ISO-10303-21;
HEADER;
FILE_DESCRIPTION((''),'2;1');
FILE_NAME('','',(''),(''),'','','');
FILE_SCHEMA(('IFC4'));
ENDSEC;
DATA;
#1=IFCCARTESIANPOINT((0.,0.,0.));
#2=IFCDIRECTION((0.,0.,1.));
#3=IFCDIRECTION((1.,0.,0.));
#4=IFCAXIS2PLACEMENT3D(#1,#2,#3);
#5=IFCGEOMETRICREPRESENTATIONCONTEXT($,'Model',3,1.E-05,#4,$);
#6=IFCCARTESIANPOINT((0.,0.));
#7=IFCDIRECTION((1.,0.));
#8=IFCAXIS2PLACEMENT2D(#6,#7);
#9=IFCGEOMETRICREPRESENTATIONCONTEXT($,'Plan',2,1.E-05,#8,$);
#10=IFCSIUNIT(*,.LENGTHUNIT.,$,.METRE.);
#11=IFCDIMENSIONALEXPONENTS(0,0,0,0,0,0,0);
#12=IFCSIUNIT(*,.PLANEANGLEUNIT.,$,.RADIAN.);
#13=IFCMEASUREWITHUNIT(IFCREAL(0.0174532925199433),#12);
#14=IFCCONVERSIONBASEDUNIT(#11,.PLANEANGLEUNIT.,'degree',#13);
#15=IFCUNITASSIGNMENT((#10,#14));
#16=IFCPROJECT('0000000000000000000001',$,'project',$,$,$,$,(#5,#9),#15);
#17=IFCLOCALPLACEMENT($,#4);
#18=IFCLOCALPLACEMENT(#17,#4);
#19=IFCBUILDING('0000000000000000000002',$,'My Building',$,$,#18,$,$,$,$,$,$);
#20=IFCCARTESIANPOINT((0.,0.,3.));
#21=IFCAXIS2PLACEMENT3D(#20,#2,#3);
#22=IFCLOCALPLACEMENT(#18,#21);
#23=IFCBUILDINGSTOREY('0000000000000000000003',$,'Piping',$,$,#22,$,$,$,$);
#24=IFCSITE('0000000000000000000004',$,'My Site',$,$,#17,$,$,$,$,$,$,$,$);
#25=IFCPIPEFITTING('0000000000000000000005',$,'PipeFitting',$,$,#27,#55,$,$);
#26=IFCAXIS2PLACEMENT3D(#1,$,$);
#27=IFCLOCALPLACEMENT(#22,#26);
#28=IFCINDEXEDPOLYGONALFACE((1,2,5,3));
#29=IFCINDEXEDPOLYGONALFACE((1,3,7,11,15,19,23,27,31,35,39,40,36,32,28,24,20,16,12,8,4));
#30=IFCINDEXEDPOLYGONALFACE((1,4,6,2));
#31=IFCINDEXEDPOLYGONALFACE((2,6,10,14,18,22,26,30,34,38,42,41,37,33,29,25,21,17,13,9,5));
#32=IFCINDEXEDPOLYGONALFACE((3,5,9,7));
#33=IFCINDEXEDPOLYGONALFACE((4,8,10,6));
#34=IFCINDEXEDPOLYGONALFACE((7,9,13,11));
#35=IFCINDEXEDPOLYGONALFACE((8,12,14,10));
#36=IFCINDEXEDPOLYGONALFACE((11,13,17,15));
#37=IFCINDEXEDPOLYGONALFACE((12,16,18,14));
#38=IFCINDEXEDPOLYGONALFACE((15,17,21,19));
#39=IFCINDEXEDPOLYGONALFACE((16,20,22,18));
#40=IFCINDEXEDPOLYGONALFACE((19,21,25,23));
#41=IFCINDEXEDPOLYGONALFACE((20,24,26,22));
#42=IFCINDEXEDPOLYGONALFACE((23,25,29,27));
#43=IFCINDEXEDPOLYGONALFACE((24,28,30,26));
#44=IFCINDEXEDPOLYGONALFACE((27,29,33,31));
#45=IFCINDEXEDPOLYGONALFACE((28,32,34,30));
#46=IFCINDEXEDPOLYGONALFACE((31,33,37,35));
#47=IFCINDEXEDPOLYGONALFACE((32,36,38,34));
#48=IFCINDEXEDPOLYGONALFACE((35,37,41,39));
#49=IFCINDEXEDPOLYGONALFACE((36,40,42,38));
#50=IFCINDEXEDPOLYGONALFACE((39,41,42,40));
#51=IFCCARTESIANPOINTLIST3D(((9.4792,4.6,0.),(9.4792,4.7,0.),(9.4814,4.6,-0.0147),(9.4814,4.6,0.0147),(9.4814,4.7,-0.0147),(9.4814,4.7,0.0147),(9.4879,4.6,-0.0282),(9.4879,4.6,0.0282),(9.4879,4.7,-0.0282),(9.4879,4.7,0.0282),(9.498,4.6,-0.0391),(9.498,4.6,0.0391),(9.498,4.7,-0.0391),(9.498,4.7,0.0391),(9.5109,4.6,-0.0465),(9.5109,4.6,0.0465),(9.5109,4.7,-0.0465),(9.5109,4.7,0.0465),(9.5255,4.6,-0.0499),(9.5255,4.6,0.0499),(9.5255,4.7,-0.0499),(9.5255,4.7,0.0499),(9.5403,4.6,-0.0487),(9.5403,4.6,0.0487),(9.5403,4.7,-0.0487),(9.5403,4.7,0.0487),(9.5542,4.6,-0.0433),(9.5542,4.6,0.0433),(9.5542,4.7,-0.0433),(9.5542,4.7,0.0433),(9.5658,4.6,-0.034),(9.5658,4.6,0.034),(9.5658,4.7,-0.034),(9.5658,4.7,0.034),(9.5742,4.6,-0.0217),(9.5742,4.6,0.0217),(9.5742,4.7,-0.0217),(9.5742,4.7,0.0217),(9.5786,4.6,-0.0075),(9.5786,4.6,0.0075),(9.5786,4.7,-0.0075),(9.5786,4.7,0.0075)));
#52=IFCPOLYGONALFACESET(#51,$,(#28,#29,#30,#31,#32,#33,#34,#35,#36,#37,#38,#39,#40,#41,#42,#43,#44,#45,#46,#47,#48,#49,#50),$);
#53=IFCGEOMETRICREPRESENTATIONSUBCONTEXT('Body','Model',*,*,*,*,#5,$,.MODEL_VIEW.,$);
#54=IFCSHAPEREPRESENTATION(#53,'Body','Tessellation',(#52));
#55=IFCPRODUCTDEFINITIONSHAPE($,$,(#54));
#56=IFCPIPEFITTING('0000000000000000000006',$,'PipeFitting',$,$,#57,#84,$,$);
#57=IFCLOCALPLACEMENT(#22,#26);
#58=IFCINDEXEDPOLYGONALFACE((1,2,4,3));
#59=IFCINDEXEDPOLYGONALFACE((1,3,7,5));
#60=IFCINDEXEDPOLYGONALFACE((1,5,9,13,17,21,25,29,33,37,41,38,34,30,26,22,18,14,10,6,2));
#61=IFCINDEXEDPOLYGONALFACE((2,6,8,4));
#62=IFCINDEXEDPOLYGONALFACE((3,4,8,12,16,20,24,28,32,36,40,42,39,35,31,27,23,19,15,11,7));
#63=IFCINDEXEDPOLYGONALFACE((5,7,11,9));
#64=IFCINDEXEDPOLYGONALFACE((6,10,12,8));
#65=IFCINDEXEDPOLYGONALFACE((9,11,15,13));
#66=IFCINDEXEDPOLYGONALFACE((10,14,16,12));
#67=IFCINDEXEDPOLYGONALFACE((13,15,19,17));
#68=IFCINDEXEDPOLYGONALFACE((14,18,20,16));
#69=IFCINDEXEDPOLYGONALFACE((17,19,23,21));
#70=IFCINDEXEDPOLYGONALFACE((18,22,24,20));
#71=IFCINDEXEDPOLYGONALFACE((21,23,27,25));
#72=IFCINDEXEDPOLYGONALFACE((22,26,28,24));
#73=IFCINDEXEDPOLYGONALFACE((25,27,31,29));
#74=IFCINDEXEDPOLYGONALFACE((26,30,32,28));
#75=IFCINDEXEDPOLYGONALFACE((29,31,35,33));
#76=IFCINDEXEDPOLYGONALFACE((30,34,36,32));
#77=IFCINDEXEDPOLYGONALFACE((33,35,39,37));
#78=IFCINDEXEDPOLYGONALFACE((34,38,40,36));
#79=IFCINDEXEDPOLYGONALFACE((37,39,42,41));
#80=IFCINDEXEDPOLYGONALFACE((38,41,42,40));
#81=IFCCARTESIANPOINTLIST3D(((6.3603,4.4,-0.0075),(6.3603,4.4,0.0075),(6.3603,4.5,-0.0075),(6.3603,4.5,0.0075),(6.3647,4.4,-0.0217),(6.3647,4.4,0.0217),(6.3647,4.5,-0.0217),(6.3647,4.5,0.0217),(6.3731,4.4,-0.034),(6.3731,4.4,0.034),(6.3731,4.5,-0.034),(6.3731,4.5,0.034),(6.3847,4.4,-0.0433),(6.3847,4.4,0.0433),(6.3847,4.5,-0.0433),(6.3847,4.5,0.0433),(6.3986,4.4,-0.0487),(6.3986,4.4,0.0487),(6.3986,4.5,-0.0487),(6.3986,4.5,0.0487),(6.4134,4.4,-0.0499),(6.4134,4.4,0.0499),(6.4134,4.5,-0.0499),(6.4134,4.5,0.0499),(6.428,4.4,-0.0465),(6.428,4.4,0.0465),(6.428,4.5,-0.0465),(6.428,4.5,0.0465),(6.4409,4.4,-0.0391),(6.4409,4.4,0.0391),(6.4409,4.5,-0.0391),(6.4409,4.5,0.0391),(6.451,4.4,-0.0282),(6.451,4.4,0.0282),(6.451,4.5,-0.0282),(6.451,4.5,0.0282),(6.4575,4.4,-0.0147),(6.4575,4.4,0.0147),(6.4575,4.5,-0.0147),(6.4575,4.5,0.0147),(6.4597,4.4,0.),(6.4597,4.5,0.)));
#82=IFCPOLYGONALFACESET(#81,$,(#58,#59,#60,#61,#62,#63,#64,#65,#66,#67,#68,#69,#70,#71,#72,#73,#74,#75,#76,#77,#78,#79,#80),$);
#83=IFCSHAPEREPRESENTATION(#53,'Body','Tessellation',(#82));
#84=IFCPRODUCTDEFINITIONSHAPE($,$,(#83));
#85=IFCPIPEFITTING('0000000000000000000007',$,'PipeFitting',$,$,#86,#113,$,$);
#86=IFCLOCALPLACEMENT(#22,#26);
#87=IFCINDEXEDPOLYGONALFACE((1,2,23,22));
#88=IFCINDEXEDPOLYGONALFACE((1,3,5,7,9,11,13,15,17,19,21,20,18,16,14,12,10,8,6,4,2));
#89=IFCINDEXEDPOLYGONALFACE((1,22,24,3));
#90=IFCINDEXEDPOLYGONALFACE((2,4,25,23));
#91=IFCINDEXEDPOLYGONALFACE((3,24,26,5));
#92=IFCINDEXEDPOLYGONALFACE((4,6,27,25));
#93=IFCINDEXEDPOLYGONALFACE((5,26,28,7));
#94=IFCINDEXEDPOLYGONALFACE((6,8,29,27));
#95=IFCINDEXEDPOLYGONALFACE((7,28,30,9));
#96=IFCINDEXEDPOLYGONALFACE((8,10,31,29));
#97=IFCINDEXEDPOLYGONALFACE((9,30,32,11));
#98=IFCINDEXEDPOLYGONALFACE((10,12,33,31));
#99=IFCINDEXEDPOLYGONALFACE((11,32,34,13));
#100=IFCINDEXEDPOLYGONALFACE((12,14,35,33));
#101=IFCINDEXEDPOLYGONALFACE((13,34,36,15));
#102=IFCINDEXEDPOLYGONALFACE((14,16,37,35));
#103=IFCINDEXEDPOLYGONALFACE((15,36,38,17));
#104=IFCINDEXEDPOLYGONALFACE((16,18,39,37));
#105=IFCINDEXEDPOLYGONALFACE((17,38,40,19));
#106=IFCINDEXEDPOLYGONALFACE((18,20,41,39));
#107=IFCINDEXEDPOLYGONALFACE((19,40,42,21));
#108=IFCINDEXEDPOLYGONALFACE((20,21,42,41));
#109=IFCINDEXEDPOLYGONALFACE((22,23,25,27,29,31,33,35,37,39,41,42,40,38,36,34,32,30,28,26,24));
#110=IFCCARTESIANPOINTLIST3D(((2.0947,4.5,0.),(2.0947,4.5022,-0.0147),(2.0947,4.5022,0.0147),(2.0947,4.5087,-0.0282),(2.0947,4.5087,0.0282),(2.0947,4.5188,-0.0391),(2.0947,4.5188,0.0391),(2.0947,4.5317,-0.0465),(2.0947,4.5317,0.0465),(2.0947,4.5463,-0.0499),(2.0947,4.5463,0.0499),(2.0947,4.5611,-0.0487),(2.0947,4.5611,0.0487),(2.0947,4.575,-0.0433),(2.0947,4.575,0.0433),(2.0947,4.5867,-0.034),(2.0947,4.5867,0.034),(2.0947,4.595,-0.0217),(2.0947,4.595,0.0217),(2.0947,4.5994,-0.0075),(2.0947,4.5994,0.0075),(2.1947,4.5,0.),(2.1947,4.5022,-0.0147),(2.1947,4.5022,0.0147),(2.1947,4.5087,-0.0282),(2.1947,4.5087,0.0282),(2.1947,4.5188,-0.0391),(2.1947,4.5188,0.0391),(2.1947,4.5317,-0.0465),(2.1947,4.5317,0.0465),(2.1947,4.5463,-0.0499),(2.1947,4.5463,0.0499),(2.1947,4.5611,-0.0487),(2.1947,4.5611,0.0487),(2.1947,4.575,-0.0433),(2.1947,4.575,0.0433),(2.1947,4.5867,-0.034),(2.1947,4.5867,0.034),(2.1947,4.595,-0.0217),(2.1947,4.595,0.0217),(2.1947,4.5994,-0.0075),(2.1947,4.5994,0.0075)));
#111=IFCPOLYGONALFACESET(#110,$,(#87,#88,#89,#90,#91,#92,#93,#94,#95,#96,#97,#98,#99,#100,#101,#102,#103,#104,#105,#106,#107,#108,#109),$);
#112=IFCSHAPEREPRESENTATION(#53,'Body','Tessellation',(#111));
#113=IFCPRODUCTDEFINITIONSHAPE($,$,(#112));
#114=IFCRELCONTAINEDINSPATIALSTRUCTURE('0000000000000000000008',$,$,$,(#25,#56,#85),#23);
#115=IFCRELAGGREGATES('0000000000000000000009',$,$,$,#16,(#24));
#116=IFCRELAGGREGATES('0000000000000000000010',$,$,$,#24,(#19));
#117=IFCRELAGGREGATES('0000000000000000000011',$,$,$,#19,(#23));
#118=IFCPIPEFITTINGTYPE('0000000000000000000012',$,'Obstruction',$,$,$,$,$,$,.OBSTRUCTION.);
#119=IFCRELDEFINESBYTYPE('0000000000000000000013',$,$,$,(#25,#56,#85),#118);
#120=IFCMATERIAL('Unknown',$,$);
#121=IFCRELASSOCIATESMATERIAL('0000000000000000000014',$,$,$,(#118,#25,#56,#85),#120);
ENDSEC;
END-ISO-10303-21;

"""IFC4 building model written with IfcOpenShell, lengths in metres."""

from ifc_helpers import new_model, entity, si_unit, converted_unit, frame, origin_with_axes, origin_2d_with_axis, place, context, subcontext, project, spatial, circle, extrude, material, material_profile, profile_set, profile_usage, type_object, element, save


model = new_model("IFC4")

# Units and contexts
model_context = context("Model", 3, precision=1e-05, world=origin_with_axes())
plan_context = context("Plan", 2, precision=1e-05, world=origin_2d_with_axis())
body_context = subcontext(model_context, "Body", "Model", "MODEL_VIEW")
ifc_project = project(units=[si_unit("LENGTHUNIT", "METRE"), converted_unit("PLANEANGLEUNIT", "degree", entity("IfcReal", 0.0174532925199433), si_unit("PLANEANGLEUNIT", "RADIAN"), dimensions=[0, 0, 0, 0, 0, 0, 0])], contexts=[model_context, plan_context])

# Site, building, storey
site_placement = place(None, origin_with_axes())
site = spatial("IfcSite", under=ifc_project, at=site_placement, Name="My Site")
building_placement = place(site_placement, origin_with_axes())
building = spatial("IfcBuilding", under=site, at=building_placement, Name="My Building")
storey_placement = place(building_placement, frame((0.0, 0.0, 3.0), z_axis=(0.0, 0.0, 1.0), x_axis=(1.0, 0.0, 0.0)))
storey = spatial("IfcBuildingStorey", under=building, at=storey_placement, Name="Piping")

# Shared definitions
ifc_material = material(Name="Unknown")

# Pipe fittings
ifc_material_profile_1 = material_profile(ifc_material, circle(Radius=0.05))
ifc_profile_set_1 = profile_set([ifc_material_profile_1])
pipe_fitting_type_1 = type_object("IfcPipeFittingType", Name="Obstruction", PredefinedType="OBSTRUCTION", material=ifc_profile_set_1)
ifc_profile_usage_1 = profile_usage(ifc_profile_set_1, cardinal=5)
pipe_fitting_1_placement = place(storey_placement, frame((9.5292, 4.6, 0.0), z_axis=(0.0, 1.0, 0.0), x_axis=(-1.0, 0.0, 0.0)))
element("IfcPipeFitting", 1, at=pipe_fitting_1_placement, inside=storey, type_object=pipe_fitting_type_1, material=ifc_profile_usage_1, Name="PipeFitting", context=body_context, shape_type="SweptSolid", body=[
    extrude(circle(Radius=0.05), origin_with_axes(), (0.0, 0.0, 1.0), 0.1),
])
ifc_profile_usage_2 = profile_usage(ifc_profile_set_1, cardinal=5)
pipe_fitting_2_placement = place(storey_placement, frame((6.4097, 4.5, 0.0), z_axis=(0.0, -1.0, 0.0), x_axis=(1.0, 0.0, 0.0)))
element("IfcPipeFitting", 2, at=pipe_fitting_2_placement, inside=storey, type_object=pipe_fitting_type_1, material=ifc_profile_usage_2, Name="PipeFitting", context=body_context, shape_type="SweptSolid", body=[
    extrude(circle(Radius=0.05), origin_with_axes(), (0.0, 0.0, 1.0), 0.1),
])
ifc_profile_usage_3 = profile_usage(ifc_profile_set_1, cardinal=5)
pipe_fitting_3_placement = place(storey_placement, frame((2.1947, 4.55, 0.0), z_axis=(-1.0, 0.0, 0.0), x_axis=(0.0, -1.0, 0.0)))
element("IfcPipeFitting", 3, at=pipe_fitting_3_placement, inside=storey, type_object=pipe_fitting_type_1, material=ifc_profile_usage_3, Name="PipeFitting", context=body_context, shape_type="SweptSolid", body=[
    extrude(circle(Radius=0.05), origin_with_axes(), (0.0, 0.0, 1.0), 0.1),
])

save(model, "model.ifc")
